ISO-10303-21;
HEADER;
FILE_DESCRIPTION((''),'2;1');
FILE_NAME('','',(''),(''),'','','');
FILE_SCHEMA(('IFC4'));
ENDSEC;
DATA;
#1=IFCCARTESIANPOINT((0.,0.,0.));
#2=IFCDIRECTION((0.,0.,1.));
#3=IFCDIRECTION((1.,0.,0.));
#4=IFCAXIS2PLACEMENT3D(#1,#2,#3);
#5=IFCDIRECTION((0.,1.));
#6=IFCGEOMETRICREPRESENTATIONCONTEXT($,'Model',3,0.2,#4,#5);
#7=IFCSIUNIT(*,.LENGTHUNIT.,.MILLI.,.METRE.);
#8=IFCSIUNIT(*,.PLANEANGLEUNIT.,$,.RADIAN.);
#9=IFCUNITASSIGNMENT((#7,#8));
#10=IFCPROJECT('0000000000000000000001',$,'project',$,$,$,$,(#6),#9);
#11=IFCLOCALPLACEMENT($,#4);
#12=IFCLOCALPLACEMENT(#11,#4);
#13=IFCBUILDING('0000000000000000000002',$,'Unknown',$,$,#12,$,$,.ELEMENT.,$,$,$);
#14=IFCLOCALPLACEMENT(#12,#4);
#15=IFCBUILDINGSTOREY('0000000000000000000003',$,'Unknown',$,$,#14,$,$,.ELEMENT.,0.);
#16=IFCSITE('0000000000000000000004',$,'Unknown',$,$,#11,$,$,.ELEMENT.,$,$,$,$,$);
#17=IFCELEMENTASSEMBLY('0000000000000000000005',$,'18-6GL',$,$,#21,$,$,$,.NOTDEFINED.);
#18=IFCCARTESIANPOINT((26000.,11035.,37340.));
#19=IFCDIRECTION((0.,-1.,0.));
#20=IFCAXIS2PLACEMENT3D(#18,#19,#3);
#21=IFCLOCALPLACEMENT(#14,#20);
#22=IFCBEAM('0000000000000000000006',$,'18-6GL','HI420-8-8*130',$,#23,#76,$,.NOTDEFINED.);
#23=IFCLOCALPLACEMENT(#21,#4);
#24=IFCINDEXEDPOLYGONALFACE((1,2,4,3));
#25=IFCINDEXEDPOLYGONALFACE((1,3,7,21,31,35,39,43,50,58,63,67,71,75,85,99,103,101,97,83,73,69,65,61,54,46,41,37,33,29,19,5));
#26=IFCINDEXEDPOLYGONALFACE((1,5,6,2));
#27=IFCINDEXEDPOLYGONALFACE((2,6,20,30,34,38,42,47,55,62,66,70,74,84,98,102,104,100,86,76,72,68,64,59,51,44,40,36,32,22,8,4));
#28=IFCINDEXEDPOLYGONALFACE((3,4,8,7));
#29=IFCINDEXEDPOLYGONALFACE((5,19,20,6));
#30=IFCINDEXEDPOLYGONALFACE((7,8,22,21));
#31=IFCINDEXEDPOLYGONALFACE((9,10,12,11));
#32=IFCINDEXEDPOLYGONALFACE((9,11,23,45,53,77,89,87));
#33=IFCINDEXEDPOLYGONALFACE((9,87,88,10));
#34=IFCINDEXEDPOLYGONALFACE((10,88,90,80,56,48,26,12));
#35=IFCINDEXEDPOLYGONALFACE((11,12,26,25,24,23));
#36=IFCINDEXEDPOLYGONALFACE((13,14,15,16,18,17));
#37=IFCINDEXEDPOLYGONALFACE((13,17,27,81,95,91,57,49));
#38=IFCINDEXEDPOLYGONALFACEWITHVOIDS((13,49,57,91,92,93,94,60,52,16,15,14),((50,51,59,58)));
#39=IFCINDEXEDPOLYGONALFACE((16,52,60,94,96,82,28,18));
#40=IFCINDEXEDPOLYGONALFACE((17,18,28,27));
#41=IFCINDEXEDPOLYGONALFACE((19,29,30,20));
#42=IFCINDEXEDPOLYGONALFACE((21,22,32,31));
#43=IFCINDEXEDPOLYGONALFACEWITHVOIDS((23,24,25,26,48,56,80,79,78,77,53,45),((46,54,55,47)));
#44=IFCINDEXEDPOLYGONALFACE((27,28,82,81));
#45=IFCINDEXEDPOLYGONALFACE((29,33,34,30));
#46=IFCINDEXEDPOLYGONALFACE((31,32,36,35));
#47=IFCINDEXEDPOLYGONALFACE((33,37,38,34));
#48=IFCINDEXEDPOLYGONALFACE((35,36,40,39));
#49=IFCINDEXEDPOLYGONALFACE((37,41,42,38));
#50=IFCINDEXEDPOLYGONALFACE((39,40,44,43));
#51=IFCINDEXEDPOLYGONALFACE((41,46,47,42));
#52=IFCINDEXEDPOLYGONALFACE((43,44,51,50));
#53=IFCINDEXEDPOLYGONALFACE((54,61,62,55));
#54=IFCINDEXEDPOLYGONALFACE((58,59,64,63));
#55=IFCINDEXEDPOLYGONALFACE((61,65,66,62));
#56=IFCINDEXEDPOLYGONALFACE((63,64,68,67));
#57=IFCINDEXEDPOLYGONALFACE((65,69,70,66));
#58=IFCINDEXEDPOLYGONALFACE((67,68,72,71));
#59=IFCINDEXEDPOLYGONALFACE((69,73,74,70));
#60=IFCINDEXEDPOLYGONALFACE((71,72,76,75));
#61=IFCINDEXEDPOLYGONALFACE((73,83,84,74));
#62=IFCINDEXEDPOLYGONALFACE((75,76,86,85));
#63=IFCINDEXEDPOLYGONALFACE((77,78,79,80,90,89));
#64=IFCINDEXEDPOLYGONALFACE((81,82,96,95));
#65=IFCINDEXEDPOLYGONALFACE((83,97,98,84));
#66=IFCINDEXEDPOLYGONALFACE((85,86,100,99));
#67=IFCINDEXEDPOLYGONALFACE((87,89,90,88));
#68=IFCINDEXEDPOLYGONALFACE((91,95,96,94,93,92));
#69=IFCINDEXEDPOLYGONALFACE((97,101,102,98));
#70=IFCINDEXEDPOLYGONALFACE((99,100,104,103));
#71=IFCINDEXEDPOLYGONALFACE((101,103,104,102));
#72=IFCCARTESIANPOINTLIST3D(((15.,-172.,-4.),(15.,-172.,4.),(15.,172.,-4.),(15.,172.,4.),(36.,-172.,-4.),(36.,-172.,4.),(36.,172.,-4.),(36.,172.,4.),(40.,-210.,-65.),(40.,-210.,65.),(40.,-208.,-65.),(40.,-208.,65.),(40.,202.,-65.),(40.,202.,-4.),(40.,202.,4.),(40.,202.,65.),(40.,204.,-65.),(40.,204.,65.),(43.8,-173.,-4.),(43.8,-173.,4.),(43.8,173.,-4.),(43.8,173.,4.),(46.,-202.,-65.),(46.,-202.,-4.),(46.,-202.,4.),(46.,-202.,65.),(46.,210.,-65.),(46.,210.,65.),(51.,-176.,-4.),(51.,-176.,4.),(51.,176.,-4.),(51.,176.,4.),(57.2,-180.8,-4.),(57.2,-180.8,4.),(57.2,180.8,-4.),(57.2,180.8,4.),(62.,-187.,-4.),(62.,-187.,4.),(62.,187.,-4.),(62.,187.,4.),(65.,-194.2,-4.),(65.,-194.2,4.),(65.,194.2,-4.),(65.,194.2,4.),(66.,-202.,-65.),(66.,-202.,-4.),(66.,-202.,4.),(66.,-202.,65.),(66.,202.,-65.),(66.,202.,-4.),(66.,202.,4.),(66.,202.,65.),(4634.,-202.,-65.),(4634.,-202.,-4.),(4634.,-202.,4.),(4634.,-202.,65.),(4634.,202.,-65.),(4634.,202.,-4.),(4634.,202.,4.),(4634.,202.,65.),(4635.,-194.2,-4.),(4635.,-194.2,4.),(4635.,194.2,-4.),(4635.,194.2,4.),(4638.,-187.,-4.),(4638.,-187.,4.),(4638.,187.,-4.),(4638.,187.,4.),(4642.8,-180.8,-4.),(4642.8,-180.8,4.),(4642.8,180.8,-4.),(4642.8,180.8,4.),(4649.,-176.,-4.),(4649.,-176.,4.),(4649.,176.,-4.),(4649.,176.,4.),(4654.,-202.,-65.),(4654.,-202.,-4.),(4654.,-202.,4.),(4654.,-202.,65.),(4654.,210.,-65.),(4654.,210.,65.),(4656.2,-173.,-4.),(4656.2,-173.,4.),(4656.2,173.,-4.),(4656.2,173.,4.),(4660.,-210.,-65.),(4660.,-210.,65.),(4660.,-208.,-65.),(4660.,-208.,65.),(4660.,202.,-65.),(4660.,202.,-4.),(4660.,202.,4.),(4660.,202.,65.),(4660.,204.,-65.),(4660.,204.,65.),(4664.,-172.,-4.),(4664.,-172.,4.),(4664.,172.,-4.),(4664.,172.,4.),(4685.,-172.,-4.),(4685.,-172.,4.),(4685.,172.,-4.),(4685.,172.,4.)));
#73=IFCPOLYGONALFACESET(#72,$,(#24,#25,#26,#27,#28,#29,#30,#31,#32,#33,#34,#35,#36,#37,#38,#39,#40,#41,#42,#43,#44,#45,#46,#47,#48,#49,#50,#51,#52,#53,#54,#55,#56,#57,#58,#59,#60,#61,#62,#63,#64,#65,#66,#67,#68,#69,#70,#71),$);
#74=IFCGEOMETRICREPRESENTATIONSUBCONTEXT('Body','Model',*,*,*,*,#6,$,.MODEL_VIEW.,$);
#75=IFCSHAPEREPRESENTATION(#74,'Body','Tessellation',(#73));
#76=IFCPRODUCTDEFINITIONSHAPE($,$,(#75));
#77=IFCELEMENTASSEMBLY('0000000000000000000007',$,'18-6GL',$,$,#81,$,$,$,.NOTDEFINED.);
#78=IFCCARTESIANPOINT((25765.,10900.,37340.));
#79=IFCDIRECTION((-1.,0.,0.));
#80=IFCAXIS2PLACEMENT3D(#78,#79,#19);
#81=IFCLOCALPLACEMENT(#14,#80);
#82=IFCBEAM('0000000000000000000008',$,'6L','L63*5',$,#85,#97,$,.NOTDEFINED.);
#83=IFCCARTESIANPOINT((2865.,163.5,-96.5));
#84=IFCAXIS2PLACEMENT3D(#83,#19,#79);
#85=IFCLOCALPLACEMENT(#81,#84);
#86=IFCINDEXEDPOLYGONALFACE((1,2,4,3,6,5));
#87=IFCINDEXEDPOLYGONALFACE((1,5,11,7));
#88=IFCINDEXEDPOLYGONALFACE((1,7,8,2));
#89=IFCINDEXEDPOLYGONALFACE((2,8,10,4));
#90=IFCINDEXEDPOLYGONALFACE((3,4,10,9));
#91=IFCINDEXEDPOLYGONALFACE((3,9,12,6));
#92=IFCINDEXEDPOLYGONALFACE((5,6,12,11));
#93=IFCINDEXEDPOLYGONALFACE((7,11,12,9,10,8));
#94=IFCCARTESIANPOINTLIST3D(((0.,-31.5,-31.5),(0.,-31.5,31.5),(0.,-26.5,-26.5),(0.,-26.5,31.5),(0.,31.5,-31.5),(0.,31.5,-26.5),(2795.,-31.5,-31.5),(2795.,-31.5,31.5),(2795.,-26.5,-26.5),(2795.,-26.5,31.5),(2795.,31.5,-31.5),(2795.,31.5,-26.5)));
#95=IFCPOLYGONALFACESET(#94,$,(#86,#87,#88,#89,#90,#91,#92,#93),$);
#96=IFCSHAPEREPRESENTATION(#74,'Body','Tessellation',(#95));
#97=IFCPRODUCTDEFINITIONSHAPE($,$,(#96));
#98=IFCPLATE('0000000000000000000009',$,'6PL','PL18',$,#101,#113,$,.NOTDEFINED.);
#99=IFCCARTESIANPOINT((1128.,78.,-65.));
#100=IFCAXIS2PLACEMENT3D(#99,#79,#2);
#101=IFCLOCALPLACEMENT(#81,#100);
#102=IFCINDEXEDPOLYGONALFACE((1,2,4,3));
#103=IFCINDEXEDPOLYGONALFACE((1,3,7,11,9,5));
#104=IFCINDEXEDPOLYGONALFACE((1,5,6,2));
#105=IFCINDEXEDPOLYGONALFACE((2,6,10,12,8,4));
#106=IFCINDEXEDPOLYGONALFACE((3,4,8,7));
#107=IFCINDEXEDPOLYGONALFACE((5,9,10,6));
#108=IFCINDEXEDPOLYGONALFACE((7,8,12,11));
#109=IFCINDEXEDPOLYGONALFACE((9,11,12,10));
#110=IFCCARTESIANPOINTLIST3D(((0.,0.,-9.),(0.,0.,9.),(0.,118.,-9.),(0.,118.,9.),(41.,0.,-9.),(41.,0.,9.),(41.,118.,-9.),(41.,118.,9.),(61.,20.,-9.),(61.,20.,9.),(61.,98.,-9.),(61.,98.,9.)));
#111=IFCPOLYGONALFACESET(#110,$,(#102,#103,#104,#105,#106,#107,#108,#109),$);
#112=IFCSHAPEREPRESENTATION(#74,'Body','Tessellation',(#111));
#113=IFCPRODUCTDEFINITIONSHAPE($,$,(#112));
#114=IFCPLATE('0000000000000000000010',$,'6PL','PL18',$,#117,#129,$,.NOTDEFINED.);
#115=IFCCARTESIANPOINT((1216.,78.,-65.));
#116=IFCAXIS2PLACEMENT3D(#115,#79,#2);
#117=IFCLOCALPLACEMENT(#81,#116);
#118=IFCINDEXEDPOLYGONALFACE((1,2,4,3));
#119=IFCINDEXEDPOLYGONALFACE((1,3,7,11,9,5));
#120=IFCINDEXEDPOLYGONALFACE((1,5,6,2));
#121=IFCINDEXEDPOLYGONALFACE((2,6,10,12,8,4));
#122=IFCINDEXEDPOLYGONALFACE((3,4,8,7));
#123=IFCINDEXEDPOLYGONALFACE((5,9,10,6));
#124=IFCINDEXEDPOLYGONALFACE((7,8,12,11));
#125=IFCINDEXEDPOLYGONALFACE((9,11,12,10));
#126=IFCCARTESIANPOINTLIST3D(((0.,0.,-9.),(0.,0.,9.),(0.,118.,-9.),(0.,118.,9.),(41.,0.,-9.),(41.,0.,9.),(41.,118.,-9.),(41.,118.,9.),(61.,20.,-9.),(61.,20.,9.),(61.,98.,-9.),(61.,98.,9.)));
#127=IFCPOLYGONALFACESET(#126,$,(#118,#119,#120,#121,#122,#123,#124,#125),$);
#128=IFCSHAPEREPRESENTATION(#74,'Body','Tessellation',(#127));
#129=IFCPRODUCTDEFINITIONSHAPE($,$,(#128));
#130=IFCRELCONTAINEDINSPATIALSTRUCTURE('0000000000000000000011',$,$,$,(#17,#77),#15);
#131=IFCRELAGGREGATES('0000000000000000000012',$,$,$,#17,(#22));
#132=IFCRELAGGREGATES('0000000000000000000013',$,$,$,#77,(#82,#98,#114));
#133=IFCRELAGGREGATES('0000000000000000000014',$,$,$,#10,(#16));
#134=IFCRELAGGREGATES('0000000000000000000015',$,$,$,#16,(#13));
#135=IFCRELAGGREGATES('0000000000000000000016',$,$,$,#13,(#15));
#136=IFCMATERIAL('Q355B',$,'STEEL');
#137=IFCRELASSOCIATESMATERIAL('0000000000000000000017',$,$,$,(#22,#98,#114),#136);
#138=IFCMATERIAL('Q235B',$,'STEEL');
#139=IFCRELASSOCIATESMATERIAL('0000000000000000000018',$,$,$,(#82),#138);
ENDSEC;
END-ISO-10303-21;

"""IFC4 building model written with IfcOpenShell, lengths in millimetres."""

from ifc_helpers import new_model, si_unit, direction, frame, origin_with_axes, place, context, subcontext, project, spatial, line, arc, indexed_curve, outline, extrude, material, element, aggregate, save


model = new_model("IFC4")

# Units and contexts
model_context = context("Model", 3, precision=0.2, world=origin_with_axes(), true_north=direction((0.0, 1.0)))
body_context = subcontext(model_context, "Body", "Model", "MODEL_VIEW")
ifc_project = project(units=[si_unit("LENGTHUNIT", "METRE", prefix="MILLI"), si_unit("PLANEANGLEUNIT", "RADIAN")], contexts=[model_context])

# Site, building, storey
site_placement = place(None, origin_with_axes())
site = spatial("IfcSite", under=ifc_project, at=site_placement, Name="Unknown", CompositionType="ELEMENT")
building_placement = place(site_placement, origin_with_axes())
building = spatial("IfcBuilding", under=site, at=building_placement, Name="Unknown", CompositionType="ELEMENT")
storey_placement = place(building_placement, origin_with_axes())
storey = spatial("IfcBuildingStorey", under=building, at=storey_placement, Name="Unknown", CompositionType="ELEMENT", Elevation=0.0)

# Shared definitions
ifc_material_1 = material(Name="Q355B", Category="STEEL")

# Element assembly, beam, voiding features
assembly_1_placement = place(storey_placement, frame((26000.0, 11035.0, 37340.0), z_axis=(0.0, -1.0, 0.0), x_axis=(1.0, 0.0, 0.0)))
assembly_1 = element("IfcElementAssembly", 1, at=assembly_1_placement, inside=storey, Name="18-6GL", PredefinedType="NOTDEFINED")
beam_1_placement = place(assembly_1_placement, origin_with_axes())
beam_1 = element("IfcBeam", 2, at=beam_1_placement, material=ifc_material_1, Name="18-6GL", Description="HI420-8-8*130", PredefinedType="NOTDEFINED", context=body_context, shape_type="SolidModel", body=[
    extrude(outline(indexed_curve([(-65.0, -210.0), (65.0, -210.0), (65.0, -202.0), (4.0, -202.0), (4.0, 202.0), (65.0, 202.0), (65.0, 210.0), (-65.0, 210.0), (-65.0, 202.0), (-4.0, 202.0), (-4.0, -202.0), (-65.0, -202.0)], segments=[line(1, 2, 3, 4, 5, 6, 7, 8, 9, 10, 11, 12, 1)])), frame((0.0, 0.0, 0.0), z_axis=(-1.0, 0.0, 0.0), x_axis=(0.0, 0.0, 1.0)), (0.0, 0.0, -1.0), 4700.0),
])
voiding_feature_1_placement = place(beam_1_placement, frame((4700.0, 210.0, 0.0), z_axis=(0.0, 0.0, 1.0), x_axis=(-1.0, 0.0, 0.0)))
element("IfcVoidingFeature", 3, at=voiding_feature_1_placement, cuts=beam_1, Name="CUTPART", PredefinedType="HOLE", context=body_context, shape_type="SolidModel", body=[
    extrude(outline(indexed_curve([(0.0, 0.0), (46.0, 0.0), (40.0, 6.0), (40.0, 8.0), (66.0, 8.0), (57.2, 29.2), (36.0, 38.0), (15.0, 38.0), (15.0, 382.0), (36.0, 382.0), (57.2, 390.8), (66.0, 412.0), (46.0, 412.0), (40.0, 418.0), (40.0, 420.0), (0.0, 420.0)], segments=[line(1, 2, 3, 4, 5), arc(5, 6, 7), line(7, 8, 9, 10), arc(10, 11, 12), line(12, 13, 14, 15, 16, 1)])), frame((0.0, 0.0, 67.5), z_axis=(0.0, 0.0, 1.0), x_axis=(1.0, 0.0, 0.0)), (0.0, 0.0, -1.0), 135.0),
])
voiding_feature_2_placement = place(beam_1_placement, frame((0.0, 210.0, 0.0), z_axis=(0.0, 0.0, -1.0), x_axis=(1.0, 0.0, 0.0)))
element("IfcVoidingFeature", 4, at=voiding_feature_2_placement, cuts=beam_1, Name="CUTPART", PredefinedType="HOLE", context=body_context, shape_type="SolidModel", body=[
    extrude(outline(indexed_curve([(0.0, 0.0), (46.0, 0.0), (40.0, 6.0), (40.0, 8.0), (66.0, 8.0), (57.2, 29.2), (36.0, 38.0), (15.0, 38.0), (15.0, 382.0), (36.0, 382.0), (57.2, 390.8), (66.0, 412.0), (46.0, 412.0), (40.0, 418.0), (40.0, 420.0), (0.0, 420.0)], segments=[line(1, 2, 3, 4, 5), arc(5, 6, 7), line(7, 8, 9, 10), arc(10, 11, 12), line(12, 13, 14, 15, 16, 1)])), frame((0.0, 0.0, 67.5), z_axis=(0.0, 0.0, 1.0), x_axis=(1.0, 0.0, 0.0)), (0.0, 0.0, -1.0), 135.0),
])
aggregate(assembly_1, [beam_1])

# Element assembly, beam, plates
assembly_2_placement = place(storey_placement, frame((25765.0, 10900.0, 37340.0), z_axis=(-1.0, 0.0, 0.0), x_axis=(0.0, -1.0, 0.0)))
assembly_2 = element("IfcElementAssembly", 5, at=assembly_2_placement, inside=storey, Name="18-6GL", PredefinedType="NOTDEFINED")
ifc_material_2 = material(Name="Q235B", Category="STEEL")
beam_2_placement = place(assembly_2_placement, frame((2865.0, 163.5, -96.5), z_axis=(0.0, -1.0, 0.0), x_axis=(-1.0, 0.0, 0.0)))
beam_2 = element("IfcBeam", 6, at=beam_2_placement, material=ifc_material_2, Name="6L", Description="L63*5", PredefinedType="NOTDEFINED", context=body_context, shape_type="SolidModel", body=[
    extrude(outline(indexed_curve([(-31.5, -31.5), (31.5, -31.5), (31.5, -26.5), (-26.5, -26.5), (-26.5, 31.5), (-31.5, 31.5)], segments=[line(1, 2, 3, 4, 5, 6, 1)])), frame((0.0, 0.0, 0.0), z_axis=(-1.0, 0.0, 0.0), x_axis=(0.0, 0.0, 1.0)), (0.0, 0.0, -1.0), 2795.0),
])
plate_1_placement = place(assembly_2_placement, frame((1128.0, 78.0, -65.0), z_axis=(-1.0, 0.0, 0.0), x_axis=(0.0, 0.0, 1.0)))
plate_1 = element("IfcPlate", 7, at=plate_1_placement, material=ifc_material_1, Name="6PL", Description="PL18", PredefinedType="NOTDEFINED", context=body_context, shape_type="SolidModel", body=[
    extrude(outline(indexed_curve([(0.0, 0.0), (41.0, 0.0), (61.0, 20.0), (61.0, 98.0), (41.0, 118.0), (0.0, 118.0)], segments=[line(1, 2, 3, 4, 5, 6, 1)])), frame((0.0, 0.0, 9.0), z_axis=(0.0, 0.0, 1.0), x_axis=(1.0, 0.0, 0.0)), (0.0, 0.0, -1.0), 18.0),
])
plate_2_placement = place(assembly_2_placement, frame((1216.0, 78.0, -65.0), z_axis=(-1.0, 0.0, 0.0), x_axis=(0.0, 0.0, 1.0)))
plate_2 = element("IfcPlate", 8, at=plate_2_placement, material=ifc_material_1, Name="6PL", Description="PL18", PredefinedType="NOTDEFINED", context=body_context, shape_type="SolidModel", body=[
    extrude(outline(indexed_curve([(0.0, 0.0), (41.0, 0.0), (61.0, 20.0), (61.0, 98.0), (41.0, 118.0), (0.0, 118.0)], segments=[line(1, 2, 3, 4, 5, 6, 1)])), frame((0.0, 0.0, 9.0), z_axis=(0.0, 0.0, 1.0), x_axis=(1.0, 0.0, 0.0)), (0.0, 0.0, -1.0), 18.0),
])
aggregate(assembly_2, [beam_2, plate_1, plate_2])

save(model, "model.ifc")
